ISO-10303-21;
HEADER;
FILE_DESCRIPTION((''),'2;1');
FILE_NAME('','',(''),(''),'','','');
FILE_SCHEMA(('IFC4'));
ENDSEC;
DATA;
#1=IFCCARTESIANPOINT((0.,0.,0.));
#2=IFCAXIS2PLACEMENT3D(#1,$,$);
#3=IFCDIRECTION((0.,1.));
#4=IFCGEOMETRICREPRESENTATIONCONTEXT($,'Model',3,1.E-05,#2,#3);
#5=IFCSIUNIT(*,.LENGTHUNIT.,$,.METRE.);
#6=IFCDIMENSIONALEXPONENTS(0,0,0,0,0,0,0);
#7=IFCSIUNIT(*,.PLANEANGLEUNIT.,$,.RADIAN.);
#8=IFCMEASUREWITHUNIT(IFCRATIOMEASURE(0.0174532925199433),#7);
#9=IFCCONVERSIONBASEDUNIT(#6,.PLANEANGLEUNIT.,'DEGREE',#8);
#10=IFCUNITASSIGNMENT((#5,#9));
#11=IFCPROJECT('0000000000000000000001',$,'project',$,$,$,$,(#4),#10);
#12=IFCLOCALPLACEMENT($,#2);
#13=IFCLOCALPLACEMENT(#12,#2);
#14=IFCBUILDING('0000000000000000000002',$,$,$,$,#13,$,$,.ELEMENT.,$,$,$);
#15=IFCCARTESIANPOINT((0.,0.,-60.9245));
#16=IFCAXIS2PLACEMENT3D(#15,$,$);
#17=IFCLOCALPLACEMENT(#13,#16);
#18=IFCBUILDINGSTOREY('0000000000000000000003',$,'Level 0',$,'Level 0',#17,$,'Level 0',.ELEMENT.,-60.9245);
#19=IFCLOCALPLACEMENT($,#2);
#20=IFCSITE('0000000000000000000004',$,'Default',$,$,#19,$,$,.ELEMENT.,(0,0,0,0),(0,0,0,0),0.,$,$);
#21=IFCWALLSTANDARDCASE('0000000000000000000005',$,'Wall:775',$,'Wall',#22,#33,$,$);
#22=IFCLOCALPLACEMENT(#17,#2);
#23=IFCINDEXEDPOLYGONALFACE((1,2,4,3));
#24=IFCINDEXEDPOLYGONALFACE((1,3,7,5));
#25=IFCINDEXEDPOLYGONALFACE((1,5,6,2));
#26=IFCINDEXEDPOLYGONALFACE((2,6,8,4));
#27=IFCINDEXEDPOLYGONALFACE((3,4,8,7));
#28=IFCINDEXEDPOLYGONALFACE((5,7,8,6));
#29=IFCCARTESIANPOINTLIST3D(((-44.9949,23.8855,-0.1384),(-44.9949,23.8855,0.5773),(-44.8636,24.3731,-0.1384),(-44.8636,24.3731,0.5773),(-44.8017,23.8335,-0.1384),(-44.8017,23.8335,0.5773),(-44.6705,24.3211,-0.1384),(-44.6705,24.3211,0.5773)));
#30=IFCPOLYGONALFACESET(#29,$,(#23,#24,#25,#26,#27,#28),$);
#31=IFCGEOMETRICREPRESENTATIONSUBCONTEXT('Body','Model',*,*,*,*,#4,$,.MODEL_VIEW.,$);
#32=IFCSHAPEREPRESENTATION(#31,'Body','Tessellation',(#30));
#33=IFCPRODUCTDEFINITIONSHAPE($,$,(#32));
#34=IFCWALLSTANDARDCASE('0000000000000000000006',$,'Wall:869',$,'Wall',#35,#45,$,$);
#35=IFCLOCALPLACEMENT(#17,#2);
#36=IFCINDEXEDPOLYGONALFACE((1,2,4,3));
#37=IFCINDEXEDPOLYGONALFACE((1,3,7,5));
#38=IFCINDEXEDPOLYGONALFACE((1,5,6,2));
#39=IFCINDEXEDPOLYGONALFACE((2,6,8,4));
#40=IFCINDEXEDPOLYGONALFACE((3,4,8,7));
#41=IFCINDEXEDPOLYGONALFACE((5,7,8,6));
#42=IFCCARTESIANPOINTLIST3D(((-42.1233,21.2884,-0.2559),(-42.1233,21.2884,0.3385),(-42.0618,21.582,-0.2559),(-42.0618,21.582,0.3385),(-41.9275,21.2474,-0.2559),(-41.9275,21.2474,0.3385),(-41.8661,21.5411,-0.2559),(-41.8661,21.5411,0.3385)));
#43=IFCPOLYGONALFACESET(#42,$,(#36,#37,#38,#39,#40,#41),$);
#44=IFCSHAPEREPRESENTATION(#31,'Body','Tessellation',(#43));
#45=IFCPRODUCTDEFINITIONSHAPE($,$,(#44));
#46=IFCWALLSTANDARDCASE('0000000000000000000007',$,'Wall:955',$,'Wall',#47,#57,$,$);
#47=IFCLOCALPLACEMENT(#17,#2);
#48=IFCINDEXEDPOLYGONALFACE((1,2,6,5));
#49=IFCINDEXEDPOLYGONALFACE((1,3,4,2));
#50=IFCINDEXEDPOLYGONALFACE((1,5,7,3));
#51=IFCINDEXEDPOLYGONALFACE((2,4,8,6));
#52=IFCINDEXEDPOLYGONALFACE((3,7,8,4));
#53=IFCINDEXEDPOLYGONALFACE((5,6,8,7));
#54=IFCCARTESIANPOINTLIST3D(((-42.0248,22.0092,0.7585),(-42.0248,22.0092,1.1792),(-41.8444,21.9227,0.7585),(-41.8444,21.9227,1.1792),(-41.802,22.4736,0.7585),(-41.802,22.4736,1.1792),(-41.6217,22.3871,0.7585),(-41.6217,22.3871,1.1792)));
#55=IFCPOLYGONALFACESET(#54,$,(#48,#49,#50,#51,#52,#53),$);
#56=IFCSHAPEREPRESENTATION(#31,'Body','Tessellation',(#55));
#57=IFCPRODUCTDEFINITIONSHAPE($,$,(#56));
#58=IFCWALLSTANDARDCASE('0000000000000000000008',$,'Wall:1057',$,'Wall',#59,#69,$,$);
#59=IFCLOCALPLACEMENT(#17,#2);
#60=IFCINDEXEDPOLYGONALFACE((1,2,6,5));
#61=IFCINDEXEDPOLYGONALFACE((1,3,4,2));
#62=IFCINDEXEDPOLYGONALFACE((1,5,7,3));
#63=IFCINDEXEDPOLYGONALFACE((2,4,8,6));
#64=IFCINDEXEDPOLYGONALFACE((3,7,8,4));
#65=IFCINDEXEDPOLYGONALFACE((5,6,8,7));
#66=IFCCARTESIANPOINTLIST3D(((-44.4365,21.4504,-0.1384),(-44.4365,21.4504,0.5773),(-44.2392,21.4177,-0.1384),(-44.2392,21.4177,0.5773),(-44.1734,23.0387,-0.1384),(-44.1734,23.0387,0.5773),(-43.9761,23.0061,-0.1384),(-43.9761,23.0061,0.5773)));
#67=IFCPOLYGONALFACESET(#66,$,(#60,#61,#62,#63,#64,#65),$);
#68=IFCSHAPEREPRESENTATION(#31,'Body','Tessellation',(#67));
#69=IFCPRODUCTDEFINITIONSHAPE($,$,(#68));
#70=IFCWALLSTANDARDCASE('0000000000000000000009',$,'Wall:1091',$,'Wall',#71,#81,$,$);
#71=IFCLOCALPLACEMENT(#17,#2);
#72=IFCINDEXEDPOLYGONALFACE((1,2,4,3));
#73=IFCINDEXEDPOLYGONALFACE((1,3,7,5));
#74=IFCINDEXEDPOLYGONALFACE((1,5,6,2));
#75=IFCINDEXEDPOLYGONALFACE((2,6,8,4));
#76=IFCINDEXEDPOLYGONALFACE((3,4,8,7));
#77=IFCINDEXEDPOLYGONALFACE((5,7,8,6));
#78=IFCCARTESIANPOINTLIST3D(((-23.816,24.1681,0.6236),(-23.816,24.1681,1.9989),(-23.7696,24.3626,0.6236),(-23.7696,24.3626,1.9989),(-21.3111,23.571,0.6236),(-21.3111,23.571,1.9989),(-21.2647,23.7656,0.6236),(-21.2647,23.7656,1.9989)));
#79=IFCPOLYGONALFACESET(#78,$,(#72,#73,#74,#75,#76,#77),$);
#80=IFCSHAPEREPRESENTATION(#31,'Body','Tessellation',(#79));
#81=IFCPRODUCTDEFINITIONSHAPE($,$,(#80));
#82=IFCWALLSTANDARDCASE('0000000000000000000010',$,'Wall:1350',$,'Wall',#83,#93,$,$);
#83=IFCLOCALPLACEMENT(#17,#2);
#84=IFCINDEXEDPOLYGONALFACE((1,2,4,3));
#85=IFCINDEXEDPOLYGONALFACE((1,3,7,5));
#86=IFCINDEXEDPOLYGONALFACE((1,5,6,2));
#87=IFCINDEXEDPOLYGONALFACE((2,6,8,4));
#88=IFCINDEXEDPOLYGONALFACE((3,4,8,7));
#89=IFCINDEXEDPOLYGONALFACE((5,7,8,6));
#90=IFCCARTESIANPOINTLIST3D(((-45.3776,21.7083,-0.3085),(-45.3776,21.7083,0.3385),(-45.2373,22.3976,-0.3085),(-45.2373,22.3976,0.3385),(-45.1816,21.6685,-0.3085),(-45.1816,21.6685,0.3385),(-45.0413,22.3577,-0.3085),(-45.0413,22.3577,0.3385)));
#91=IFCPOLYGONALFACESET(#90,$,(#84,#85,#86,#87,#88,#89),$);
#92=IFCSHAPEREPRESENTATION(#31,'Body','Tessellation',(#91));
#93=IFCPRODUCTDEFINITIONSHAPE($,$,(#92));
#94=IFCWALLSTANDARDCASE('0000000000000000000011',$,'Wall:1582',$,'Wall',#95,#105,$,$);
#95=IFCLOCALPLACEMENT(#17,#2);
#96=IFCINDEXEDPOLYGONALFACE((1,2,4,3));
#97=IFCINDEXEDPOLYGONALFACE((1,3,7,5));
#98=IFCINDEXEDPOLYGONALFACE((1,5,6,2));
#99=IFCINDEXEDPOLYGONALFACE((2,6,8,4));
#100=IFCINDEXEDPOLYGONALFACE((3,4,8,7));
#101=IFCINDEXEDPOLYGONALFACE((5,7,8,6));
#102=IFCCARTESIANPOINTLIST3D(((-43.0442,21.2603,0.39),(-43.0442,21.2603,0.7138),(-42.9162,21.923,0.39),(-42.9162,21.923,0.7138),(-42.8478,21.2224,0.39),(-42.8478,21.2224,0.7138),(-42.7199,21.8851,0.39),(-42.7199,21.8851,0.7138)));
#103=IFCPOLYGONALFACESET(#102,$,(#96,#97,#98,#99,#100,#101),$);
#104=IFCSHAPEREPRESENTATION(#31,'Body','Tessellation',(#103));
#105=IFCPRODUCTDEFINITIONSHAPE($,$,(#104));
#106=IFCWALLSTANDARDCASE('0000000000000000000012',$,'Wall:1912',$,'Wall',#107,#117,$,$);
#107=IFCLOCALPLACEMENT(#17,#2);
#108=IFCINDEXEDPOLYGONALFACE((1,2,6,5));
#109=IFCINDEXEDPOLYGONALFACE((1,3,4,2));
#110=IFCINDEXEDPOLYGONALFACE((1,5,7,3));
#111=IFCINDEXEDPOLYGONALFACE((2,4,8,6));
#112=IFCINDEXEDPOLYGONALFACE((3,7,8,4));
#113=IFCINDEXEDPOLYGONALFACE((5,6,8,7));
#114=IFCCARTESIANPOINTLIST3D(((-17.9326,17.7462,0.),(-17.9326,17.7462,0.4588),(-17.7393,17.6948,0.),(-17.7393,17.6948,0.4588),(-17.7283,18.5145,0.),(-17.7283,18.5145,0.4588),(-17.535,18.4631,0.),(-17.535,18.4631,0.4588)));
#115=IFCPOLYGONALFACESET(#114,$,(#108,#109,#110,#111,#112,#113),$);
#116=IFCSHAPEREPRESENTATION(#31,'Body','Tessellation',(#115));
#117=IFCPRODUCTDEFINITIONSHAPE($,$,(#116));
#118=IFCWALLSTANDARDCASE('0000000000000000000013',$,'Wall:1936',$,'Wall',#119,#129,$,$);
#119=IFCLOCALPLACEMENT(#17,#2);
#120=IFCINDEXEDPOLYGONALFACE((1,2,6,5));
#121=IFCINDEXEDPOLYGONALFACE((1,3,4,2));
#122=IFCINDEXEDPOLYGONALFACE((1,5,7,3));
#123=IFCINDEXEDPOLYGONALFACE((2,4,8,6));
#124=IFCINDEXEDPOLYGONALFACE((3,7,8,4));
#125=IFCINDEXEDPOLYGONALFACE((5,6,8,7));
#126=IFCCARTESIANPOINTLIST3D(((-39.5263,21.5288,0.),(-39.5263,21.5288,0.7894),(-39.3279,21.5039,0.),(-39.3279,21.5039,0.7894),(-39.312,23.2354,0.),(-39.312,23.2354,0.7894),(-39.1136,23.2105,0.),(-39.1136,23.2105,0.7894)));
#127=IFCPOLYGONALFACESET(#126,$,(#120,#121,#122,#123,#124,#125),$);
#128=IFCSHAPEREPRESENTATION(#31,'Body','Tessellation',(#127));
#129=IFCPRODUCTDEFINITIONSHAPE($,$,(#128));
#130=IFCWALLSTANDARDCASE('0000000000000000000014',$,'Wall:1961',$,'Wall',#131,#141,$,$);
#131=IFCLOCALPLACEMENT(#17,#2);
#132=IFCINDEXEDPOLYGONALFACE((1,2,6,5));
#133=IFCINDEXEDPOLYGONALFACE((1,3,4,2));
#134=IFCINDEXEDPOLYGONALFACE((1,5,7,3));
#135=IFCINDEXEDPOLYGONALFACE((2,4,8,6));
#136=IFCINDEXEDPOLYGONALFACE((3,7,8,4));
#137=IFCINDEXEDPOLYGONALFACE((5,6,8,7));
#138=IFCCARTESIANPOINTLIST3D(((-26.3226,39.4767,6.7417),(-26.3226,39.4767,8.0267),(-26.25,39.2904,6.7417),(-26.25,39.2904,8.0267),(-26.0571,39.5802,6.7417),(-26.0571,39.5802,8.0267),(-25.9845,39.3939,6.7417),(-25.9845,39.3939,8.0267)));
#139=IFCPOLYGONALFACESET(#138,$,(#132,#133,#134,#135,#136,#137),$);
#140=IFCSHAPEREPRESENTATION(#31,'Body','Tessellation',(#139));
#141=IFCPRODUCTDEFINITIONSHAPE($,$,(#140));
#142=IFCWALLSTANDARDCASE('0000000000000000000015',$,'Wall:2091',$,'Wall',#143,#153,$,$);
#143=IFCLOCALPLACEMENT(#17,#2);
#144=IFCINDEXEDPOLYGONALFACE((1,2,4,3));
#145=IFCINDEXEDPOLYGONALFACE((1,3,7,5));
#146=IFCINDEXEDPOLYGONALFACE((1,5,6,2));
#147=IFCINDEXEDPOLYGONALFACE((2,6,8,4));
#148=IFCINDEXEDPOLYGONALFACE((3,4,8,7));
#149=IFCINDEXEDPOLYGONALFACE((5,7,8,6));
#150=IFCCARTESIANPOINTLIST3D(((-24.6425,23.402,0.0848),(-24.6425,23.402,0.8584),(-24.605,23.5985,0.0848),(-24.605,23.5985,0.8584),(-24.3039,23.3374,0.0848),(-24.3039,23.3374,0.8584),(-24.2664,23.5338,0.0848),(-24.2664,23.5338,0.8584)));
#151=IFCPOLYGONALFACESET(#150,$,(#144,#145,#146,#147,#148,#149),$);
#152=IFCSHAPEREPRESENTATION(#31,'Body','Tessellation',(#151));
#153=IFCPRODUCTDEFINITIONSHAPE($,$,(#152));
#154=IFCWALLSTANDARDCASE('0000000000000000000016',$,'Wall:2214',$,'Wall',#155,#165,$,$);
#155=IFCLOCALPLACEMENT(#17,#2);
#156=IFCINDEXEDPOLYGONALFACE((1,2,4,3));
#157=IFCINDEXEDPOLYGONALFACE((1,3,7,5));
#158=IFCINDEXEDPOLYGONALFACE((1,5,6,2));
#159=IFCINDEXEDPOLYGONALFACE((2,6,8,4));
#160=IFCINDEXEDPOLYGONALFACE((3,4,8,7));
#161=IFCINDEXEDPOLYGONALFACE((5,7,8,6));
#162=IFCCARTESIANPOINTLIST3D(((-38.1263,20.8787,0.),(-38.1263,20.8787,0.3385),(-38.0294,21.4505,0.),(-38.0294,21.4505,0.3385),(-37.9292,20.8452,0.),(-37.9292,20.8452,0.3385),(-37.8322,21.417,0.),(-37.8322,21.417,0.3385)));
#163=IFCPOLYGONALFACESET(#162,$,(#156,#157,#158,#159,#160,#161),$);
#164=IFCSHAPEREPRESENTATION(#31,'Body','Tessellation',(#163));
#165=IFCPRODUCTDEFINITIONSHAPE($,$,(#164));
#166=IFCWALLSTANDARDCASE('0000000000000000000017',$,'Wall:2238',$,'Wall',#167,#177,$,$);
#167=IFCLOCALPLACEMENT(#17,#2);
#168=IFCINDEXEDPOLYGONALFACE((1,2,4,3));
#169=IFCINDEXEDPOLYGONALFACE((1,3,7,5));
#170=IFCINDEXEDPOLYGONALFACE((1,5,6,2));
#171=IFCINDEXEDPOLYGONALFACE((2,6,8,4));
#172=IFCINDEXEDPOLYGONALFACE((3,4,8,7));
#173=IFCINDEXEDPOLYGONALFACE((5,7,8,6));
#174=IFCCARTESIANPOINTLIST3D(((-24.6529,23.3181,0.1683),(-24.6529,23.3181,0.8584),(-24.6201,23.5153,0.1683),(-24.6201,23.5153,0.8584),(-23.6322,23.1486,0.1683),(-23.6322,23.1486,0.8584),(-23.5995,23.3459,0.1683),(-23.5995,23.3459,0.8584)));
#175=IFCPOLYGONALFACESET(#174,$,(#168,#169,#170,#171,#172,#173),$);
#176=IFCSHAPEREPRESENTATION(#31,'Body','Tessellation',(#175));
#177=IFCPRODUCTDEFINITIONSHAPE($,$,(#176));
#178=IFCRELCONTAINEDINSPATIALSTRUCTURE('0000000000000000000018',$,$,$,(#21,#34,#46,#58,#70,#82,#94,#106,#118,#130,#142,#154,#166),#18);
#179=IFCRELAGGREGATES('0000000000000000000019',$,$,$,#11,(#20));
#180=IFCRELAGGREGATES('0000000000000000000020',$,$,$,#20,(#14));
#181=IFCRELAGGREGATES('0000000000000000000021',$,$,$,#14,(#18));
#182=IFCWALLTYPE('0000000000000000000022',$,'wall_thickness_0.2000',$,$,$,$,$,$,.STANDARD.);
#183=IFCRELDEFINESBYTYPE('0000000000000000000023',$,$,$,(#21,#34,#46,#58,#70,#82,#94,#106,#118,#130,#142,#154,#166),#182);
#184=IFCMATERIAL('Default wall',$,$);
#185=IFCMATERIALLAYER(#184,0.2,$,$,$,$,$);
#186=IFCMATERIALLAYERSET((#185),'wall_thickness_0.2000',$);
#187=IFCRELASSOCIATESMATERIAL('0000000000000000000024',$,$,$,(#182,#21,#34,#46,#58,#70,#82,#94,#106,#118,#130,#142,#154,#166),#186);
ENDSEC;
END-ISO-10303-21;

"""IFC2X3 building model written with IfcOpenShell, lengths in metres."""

from ifc_helpers import new_model, entity, si_unit, converted_unit, direction, frame, origin, place, context, subcontext, project, spatial, polyline, outline, extrude, material, layer, layer_set, layer_usage, type_object, element, save


model = new_model("IFC2X3")

# Units and contexts
model_context = context("Model", 3, precision=1e-05, world=origin(), true_north=direction((0.0, 1.0)))
body_context = subcontext(model_context, "Body", "Model", "MODEL_VIEW")
ifc_project = project(units=[si_unit("LENGTHUNIT", "METRE"), converted_unit("PLANEANGLEUNIT", "DEGREE", entity("IfcRatioMeasure", 0.0174532925199433), si_unit("PLANEANGLEUNIT", "RADIAN"), dimensions=[0, 0, 0, 0, 0, 0, 0])], contexts=[model_context])

# Site, building, storey
site_placement = place(None, origin())
site = spatial("IfcSite", under=ifc_project, at=site_placement, Name="Default", CompositionType="ELEMENT", RefLatitude=(0, 0, 0, 0), RefLongitude=(0, 0, 0, 0), RefElevation=0.0)
placement_1 = place(None, origin())
building_placement = place(placement_1, origin())
building = spatial("IfcBuilding", under=site, at=building_placement, CompositionType="ELEMENT")
storey_placement = place(building_placement, frame((0.0, 0.0, -60.9245)))
storey = spatial("IfcBuildingStorey", under=building, at=storey_placement, Name="Level 0", ObjectType="Level 0", LongName="Level 0", CompositionType="ELEMENT", Elevation=-60.9245)

# Walls
ifc_material = material(Name="Default wall")
ifc_layer = layer(ifc_material, 0.2)
ifc_layer_set = layer_set([ifc_layer], Name="wall_thickness_0.2000")
ifc_layer_usage = layer_usage(ifc_layer_set, "AXIS2", "POSITIVE", -0.1)
wall_type = type_object("IfcWallType", Name="wall_thickness_0.2000", PredefinedType="STANDARD", material=ifc_layer_set)
placement_2 = place(building_placement, frame((0.0, 0.0, -61.0629)))
wall_1_placement = place(placement_2, frame((-44.8983, 23.8595, 0.0), z_axis=(0.0, 0.0, 1.0), x_axis=(0.259935, 0.965626, 0.0)))
element("IfcWallStandardCase", 1, at=wall_1_placement, inside=storey, type_object=wall_type, material=ifc_layer_usage, Name="Wall:775", ObjectType="Wall", context=body_context, shape_type="SweptSolid", body=[
    extrude(outline(polyline([(0.505, -0.1), (0.505, 0.1), (0.0, 0.1), (0.0, -0.1), (0.505, -0.1)])), origin(), (0.0, 0.0, 1.0), 0.7156),
])
placement_3 = place(building_placement, frame((0.0, 0.0, -61.1804)))
wall_2_placement = place(placement_3, frame((-41.9639, 21.5615, 0.0), z_axis=(0.0, 0.0, 1.0), x_axis=(-0.204823, -0.978799, 0.0)))
element("IfcWallStandardCase", 2, at=wall_2_placement, inside=storey, type_object=wall_type, material=ifc_layer_usage, Name="Wall:869", ObjectType="Wall", context=body_context, shape_type="SweptSolid", body=[
    extrude(outline(polyline([(0.3, -0.1), (0.3, 0.1), (0.0, 0.1), (0.0, -0.1), (0.3, -0.1)])), origin(), (0.0, 0.0, 1.0), 0.5944),
])
placement_4 = place(building_placement, frame((0.0, 0.0, -60.166)))
wall_3_placement = place(placement_4, frame((-41.9346, 21.966, 0.0), z_axis=(0.0, 0.0, 1.0), x_axis=(0.432543, 0.901614, 0.0)))
element("IfcWallStandardCase", 3, at=wall_3_placement, inside=storey, type_object=wall_type, material=ifc_layer_usage, Name="Wall:955", ObjectType="Wall", context=body_context, shape_type="SweptSolid", body=[
    extrude(outline(polyline([(0.515, -0.1), (0.515, 0.1), (0.0, 0.1), (0.0, -0.1), (0.515, -0.1)])), origin(), (0.0, 0.0, 1.0), 0.4207),
])
placement_5 = place(building_placement, frame((0.0, 0.0, -61.0629)))
wall_4_placement = place(placement_5, frame((-44.3379, 21.434, 0.0), z_axis=(0.0, 0.0, 1.0), x_axis=(0.163399, 0.98656, 0.0)))
element("IfcWallStandardCase", 4, at=wall_4_placement, inside=storey, type_object=wall_type, material=ifc_layer_usage, Name="Wall:1057", ObjectType="Wall", context=body_context, shape_type="SweptSolid", body=[
    extrude(outline(polyline([(1.61, -0.1), (1.61, 0.1), (0.0, 0.1), (0.0, -0.1), (1.61, -0.1)])), origin(), (0.0, 0.0, 1.0), 0.7156),
])
placement_6 = place(building_placement, frame((0.0, 0.0, -60.3009)))
wall_5_placement = place(placement_6, frame((-23.7928, 24.2653, 0.0), z_axis=(0.0, 0.0, 1.0), x_axis=(0.972751, -0.231853, 0.0)))
element("IfcWallStandardCase", 5, at=wall_5_placement, inside=storey, type_object=wall_type, material=ifc_layer_usage, Name="Wall:1091", ObjectType="Wall", context=body_context, shape_type="SweptSolid", body=[
    extrude(outline(polyline([(2.5751, -0.1), (2.5751, 0.1), (0.0, 0.1), (0.0, -0.1), (2.5751, -0.1)])), origin(), (0.0, 0.0, 1.0), 1.3753),
])
placement_7 = place(building_placement, frame((0.0, 0.0, -61.233)))
wall_6_placement = place(placement_7, frame((-45.1393, 22.3776, 0.0), z_axis=(0.0, 0.0, 1.0), x_axis=(-0.199472, -0.979904, 0.0)))
element("IfcWallStandardCase", 6, at=wall_6_placement, inside=storey, type_object=wall_type, material=ifc_layer_usage, Name="Wall:1350", ObjectType="Wall", context=body_context, shape_type="SweptSolid", body=[
    extrude(outline(polyline([(0.7034, -0.1), (0.7034, 0.1), (0.0, 0.1), (0.0, -0.1), (0.7034, -0.1)])), origin(), (0.0, 0.0, 1.0), 0.647),
])
placement_8 = place(building_placement, frame((0.0, 0.0, -60.5345)))
wall_7_placement = place(placement_8, frame((-42.946, 21.2413, 0.0), z_axis=(0.0, 0.0, 1.0), x_axis=(0.189571, 0.981867, 0.0)))
element("IfcWallStandardCase", 7, at=wall_7_placement, inside=storey, type_object=wall_type, material=ifc_layer_usage, Name="Wall:1582", ObjectType="Wall", context=body_context, shape_type="SweptSolid", body=[
    extrude(outline(polyline([(0.675, -0.1), (0.675, 0.1), (0.0, 0.1), (0.0, -0.1), (0.675, -0.1)])), origin(), (0.0, 0.0, 1.0), 0.3237),
])
wall_8_placement = place(storey_placement, frame((-17.836, 17.7205, 0.0), z_axis=(0.0, 0.0, 1.0), x_axis=(0.256986, 0.966415, 0.0)))
element("IfcWallStandardCase", 8, at=wall_8_placement, inside=storey, type_object=wall_type, material=ifc_layer_usage, Name="Wall:1912", ObjectType="Wall", context=body_context, shape_type="SweptSolid", body=[
    extrude(outline(polyline([(0.795, -0.1), (0.795, 0.1), (0.0, 0.1), (0.0, -0.1), (0.795, -0.1)])), origin(), (0.0, 0.0, 1.0), 0.4588),
])
wall_9_placement = place(storey_placement, frame((-39.2128, 23.223, 0.0), z_axis=(0.0, 0.0, 1.0), x_axis=(-0.124599, -0.992207, 0.0)))
element("IfcWallStandardCase", 9, at=wall_9_placement, inside=storey, type_object=wall_type, material=ifc_layer_usage, Name="Wall:1936", ObjectType="Wall", context=body_context, shape_type="SweptSolid", body=[
    extrude(outline(polyline([(1.72, -0.1), (1.72, 0.1), (0.0, 0.1), (0.0, -0.1), (1.72, -0.1)])), origin(), (0.0, 0.0, 1.0), 0.7894),
])
placement_9 = place(building_placement, frame((0.0, 0.0, -54.1828)))
wall_10_placement = place(placement_9, frame((-26.0208, 39.487, 0.0), z_axis=(0.0, 0.0, 1.0), x_axis=(-0.931701, -0.363225, 0.0)))
element("IfcWallStandardCase", 10, at=wall_10_placement, inside=storey, type_object=wall_type, material=ifc_layer_usage, Name="Wall:1961", ObjectType="Wall", context=body_context, shape_type="SweptSolid", body=[
    extrude(outline(polyline([(0.285, -0.1), (0.285, 0.1), (0.0, 0.1), (0.0, -0.1), (0.285, -0.1)])), origin(), (0.0, 0.0, 1.0), 1.285),
])
placement_10 = place(building_placement, frame((0.0, 0.0, -60.8397)))
wall_11_placement = place(placement_10, frame((-24.6237, 23.5002, 0.0), z_axis=(0.0, 0.0, 1.0), x_axis=(0.982272, -0.187459, 0.0)))
element("IfcWallStandardCase", 11, at=wall_11_placement, inside=storey, type_object=wall_type, material=ifc_layer_usage, Name="Wall:2091", ObjectType="Wall", context=body_context, shape_type="SweptSolid", body=[
    extrude(outline(polyline([(0.3447, -0.1), (0.3447, 0.1), (0.0, 0.1), (0.0, -0.1), (0.3447, -0.1)])), origin(), (0.0, 0.0, 1.0), 0.7736),
])
wall_12_placement = place(storey_placement, frame((-38.0278, 20.8619, 0.0), z_axis=(0.0, 0.0, 1.0), x_axis=(0.167216, 0.98592, 0.0)))
element("IfcWallStandardCase", 12, at=wall_12_placement, inside=storey, type_object=wall_type, material=ifc_layer_usage, Name="Wall:2214", ObjectType="Wall", context=body_context, shape_type="SweptSolid", body=[
    extrude(outline(polyline([(0.58, -0.1), (0.58, 0.1), (0.0, 0.1), (0.0, -0.1), (0.58, -0.1)])), origin(), (0.0, 0.0, 1.0), 0.3385),
])
placement_11 = place(building_placement, frame((0.0, 0.0, -60.7562)))
wall_13_placement = place(placement_11, frame((-24.6365, 23.4167, 0.0), z_axis=(0.0, 0.0, 1.0), x_axis=(0.986496, -0.163787, 0.0)))
element("IfcWallStandardCase", 13, at=wall_13_placement, inside=storey, type_object=wall_type, material=ifc_layer_usage, Name="Wall:2238", ObjectType="Wall", context=body_context, shape_type="SweptSolid", body=[
    extrude(outline(polyline([(1.0346, -0.1), (1.0346, 0.1), (0.0, 0.1), (0.0, -0.1), (1.0346, -0.1)])), origin(), (0.0, 0.0, 1.0), 0.69),
])

save(model, "model.ifc")
